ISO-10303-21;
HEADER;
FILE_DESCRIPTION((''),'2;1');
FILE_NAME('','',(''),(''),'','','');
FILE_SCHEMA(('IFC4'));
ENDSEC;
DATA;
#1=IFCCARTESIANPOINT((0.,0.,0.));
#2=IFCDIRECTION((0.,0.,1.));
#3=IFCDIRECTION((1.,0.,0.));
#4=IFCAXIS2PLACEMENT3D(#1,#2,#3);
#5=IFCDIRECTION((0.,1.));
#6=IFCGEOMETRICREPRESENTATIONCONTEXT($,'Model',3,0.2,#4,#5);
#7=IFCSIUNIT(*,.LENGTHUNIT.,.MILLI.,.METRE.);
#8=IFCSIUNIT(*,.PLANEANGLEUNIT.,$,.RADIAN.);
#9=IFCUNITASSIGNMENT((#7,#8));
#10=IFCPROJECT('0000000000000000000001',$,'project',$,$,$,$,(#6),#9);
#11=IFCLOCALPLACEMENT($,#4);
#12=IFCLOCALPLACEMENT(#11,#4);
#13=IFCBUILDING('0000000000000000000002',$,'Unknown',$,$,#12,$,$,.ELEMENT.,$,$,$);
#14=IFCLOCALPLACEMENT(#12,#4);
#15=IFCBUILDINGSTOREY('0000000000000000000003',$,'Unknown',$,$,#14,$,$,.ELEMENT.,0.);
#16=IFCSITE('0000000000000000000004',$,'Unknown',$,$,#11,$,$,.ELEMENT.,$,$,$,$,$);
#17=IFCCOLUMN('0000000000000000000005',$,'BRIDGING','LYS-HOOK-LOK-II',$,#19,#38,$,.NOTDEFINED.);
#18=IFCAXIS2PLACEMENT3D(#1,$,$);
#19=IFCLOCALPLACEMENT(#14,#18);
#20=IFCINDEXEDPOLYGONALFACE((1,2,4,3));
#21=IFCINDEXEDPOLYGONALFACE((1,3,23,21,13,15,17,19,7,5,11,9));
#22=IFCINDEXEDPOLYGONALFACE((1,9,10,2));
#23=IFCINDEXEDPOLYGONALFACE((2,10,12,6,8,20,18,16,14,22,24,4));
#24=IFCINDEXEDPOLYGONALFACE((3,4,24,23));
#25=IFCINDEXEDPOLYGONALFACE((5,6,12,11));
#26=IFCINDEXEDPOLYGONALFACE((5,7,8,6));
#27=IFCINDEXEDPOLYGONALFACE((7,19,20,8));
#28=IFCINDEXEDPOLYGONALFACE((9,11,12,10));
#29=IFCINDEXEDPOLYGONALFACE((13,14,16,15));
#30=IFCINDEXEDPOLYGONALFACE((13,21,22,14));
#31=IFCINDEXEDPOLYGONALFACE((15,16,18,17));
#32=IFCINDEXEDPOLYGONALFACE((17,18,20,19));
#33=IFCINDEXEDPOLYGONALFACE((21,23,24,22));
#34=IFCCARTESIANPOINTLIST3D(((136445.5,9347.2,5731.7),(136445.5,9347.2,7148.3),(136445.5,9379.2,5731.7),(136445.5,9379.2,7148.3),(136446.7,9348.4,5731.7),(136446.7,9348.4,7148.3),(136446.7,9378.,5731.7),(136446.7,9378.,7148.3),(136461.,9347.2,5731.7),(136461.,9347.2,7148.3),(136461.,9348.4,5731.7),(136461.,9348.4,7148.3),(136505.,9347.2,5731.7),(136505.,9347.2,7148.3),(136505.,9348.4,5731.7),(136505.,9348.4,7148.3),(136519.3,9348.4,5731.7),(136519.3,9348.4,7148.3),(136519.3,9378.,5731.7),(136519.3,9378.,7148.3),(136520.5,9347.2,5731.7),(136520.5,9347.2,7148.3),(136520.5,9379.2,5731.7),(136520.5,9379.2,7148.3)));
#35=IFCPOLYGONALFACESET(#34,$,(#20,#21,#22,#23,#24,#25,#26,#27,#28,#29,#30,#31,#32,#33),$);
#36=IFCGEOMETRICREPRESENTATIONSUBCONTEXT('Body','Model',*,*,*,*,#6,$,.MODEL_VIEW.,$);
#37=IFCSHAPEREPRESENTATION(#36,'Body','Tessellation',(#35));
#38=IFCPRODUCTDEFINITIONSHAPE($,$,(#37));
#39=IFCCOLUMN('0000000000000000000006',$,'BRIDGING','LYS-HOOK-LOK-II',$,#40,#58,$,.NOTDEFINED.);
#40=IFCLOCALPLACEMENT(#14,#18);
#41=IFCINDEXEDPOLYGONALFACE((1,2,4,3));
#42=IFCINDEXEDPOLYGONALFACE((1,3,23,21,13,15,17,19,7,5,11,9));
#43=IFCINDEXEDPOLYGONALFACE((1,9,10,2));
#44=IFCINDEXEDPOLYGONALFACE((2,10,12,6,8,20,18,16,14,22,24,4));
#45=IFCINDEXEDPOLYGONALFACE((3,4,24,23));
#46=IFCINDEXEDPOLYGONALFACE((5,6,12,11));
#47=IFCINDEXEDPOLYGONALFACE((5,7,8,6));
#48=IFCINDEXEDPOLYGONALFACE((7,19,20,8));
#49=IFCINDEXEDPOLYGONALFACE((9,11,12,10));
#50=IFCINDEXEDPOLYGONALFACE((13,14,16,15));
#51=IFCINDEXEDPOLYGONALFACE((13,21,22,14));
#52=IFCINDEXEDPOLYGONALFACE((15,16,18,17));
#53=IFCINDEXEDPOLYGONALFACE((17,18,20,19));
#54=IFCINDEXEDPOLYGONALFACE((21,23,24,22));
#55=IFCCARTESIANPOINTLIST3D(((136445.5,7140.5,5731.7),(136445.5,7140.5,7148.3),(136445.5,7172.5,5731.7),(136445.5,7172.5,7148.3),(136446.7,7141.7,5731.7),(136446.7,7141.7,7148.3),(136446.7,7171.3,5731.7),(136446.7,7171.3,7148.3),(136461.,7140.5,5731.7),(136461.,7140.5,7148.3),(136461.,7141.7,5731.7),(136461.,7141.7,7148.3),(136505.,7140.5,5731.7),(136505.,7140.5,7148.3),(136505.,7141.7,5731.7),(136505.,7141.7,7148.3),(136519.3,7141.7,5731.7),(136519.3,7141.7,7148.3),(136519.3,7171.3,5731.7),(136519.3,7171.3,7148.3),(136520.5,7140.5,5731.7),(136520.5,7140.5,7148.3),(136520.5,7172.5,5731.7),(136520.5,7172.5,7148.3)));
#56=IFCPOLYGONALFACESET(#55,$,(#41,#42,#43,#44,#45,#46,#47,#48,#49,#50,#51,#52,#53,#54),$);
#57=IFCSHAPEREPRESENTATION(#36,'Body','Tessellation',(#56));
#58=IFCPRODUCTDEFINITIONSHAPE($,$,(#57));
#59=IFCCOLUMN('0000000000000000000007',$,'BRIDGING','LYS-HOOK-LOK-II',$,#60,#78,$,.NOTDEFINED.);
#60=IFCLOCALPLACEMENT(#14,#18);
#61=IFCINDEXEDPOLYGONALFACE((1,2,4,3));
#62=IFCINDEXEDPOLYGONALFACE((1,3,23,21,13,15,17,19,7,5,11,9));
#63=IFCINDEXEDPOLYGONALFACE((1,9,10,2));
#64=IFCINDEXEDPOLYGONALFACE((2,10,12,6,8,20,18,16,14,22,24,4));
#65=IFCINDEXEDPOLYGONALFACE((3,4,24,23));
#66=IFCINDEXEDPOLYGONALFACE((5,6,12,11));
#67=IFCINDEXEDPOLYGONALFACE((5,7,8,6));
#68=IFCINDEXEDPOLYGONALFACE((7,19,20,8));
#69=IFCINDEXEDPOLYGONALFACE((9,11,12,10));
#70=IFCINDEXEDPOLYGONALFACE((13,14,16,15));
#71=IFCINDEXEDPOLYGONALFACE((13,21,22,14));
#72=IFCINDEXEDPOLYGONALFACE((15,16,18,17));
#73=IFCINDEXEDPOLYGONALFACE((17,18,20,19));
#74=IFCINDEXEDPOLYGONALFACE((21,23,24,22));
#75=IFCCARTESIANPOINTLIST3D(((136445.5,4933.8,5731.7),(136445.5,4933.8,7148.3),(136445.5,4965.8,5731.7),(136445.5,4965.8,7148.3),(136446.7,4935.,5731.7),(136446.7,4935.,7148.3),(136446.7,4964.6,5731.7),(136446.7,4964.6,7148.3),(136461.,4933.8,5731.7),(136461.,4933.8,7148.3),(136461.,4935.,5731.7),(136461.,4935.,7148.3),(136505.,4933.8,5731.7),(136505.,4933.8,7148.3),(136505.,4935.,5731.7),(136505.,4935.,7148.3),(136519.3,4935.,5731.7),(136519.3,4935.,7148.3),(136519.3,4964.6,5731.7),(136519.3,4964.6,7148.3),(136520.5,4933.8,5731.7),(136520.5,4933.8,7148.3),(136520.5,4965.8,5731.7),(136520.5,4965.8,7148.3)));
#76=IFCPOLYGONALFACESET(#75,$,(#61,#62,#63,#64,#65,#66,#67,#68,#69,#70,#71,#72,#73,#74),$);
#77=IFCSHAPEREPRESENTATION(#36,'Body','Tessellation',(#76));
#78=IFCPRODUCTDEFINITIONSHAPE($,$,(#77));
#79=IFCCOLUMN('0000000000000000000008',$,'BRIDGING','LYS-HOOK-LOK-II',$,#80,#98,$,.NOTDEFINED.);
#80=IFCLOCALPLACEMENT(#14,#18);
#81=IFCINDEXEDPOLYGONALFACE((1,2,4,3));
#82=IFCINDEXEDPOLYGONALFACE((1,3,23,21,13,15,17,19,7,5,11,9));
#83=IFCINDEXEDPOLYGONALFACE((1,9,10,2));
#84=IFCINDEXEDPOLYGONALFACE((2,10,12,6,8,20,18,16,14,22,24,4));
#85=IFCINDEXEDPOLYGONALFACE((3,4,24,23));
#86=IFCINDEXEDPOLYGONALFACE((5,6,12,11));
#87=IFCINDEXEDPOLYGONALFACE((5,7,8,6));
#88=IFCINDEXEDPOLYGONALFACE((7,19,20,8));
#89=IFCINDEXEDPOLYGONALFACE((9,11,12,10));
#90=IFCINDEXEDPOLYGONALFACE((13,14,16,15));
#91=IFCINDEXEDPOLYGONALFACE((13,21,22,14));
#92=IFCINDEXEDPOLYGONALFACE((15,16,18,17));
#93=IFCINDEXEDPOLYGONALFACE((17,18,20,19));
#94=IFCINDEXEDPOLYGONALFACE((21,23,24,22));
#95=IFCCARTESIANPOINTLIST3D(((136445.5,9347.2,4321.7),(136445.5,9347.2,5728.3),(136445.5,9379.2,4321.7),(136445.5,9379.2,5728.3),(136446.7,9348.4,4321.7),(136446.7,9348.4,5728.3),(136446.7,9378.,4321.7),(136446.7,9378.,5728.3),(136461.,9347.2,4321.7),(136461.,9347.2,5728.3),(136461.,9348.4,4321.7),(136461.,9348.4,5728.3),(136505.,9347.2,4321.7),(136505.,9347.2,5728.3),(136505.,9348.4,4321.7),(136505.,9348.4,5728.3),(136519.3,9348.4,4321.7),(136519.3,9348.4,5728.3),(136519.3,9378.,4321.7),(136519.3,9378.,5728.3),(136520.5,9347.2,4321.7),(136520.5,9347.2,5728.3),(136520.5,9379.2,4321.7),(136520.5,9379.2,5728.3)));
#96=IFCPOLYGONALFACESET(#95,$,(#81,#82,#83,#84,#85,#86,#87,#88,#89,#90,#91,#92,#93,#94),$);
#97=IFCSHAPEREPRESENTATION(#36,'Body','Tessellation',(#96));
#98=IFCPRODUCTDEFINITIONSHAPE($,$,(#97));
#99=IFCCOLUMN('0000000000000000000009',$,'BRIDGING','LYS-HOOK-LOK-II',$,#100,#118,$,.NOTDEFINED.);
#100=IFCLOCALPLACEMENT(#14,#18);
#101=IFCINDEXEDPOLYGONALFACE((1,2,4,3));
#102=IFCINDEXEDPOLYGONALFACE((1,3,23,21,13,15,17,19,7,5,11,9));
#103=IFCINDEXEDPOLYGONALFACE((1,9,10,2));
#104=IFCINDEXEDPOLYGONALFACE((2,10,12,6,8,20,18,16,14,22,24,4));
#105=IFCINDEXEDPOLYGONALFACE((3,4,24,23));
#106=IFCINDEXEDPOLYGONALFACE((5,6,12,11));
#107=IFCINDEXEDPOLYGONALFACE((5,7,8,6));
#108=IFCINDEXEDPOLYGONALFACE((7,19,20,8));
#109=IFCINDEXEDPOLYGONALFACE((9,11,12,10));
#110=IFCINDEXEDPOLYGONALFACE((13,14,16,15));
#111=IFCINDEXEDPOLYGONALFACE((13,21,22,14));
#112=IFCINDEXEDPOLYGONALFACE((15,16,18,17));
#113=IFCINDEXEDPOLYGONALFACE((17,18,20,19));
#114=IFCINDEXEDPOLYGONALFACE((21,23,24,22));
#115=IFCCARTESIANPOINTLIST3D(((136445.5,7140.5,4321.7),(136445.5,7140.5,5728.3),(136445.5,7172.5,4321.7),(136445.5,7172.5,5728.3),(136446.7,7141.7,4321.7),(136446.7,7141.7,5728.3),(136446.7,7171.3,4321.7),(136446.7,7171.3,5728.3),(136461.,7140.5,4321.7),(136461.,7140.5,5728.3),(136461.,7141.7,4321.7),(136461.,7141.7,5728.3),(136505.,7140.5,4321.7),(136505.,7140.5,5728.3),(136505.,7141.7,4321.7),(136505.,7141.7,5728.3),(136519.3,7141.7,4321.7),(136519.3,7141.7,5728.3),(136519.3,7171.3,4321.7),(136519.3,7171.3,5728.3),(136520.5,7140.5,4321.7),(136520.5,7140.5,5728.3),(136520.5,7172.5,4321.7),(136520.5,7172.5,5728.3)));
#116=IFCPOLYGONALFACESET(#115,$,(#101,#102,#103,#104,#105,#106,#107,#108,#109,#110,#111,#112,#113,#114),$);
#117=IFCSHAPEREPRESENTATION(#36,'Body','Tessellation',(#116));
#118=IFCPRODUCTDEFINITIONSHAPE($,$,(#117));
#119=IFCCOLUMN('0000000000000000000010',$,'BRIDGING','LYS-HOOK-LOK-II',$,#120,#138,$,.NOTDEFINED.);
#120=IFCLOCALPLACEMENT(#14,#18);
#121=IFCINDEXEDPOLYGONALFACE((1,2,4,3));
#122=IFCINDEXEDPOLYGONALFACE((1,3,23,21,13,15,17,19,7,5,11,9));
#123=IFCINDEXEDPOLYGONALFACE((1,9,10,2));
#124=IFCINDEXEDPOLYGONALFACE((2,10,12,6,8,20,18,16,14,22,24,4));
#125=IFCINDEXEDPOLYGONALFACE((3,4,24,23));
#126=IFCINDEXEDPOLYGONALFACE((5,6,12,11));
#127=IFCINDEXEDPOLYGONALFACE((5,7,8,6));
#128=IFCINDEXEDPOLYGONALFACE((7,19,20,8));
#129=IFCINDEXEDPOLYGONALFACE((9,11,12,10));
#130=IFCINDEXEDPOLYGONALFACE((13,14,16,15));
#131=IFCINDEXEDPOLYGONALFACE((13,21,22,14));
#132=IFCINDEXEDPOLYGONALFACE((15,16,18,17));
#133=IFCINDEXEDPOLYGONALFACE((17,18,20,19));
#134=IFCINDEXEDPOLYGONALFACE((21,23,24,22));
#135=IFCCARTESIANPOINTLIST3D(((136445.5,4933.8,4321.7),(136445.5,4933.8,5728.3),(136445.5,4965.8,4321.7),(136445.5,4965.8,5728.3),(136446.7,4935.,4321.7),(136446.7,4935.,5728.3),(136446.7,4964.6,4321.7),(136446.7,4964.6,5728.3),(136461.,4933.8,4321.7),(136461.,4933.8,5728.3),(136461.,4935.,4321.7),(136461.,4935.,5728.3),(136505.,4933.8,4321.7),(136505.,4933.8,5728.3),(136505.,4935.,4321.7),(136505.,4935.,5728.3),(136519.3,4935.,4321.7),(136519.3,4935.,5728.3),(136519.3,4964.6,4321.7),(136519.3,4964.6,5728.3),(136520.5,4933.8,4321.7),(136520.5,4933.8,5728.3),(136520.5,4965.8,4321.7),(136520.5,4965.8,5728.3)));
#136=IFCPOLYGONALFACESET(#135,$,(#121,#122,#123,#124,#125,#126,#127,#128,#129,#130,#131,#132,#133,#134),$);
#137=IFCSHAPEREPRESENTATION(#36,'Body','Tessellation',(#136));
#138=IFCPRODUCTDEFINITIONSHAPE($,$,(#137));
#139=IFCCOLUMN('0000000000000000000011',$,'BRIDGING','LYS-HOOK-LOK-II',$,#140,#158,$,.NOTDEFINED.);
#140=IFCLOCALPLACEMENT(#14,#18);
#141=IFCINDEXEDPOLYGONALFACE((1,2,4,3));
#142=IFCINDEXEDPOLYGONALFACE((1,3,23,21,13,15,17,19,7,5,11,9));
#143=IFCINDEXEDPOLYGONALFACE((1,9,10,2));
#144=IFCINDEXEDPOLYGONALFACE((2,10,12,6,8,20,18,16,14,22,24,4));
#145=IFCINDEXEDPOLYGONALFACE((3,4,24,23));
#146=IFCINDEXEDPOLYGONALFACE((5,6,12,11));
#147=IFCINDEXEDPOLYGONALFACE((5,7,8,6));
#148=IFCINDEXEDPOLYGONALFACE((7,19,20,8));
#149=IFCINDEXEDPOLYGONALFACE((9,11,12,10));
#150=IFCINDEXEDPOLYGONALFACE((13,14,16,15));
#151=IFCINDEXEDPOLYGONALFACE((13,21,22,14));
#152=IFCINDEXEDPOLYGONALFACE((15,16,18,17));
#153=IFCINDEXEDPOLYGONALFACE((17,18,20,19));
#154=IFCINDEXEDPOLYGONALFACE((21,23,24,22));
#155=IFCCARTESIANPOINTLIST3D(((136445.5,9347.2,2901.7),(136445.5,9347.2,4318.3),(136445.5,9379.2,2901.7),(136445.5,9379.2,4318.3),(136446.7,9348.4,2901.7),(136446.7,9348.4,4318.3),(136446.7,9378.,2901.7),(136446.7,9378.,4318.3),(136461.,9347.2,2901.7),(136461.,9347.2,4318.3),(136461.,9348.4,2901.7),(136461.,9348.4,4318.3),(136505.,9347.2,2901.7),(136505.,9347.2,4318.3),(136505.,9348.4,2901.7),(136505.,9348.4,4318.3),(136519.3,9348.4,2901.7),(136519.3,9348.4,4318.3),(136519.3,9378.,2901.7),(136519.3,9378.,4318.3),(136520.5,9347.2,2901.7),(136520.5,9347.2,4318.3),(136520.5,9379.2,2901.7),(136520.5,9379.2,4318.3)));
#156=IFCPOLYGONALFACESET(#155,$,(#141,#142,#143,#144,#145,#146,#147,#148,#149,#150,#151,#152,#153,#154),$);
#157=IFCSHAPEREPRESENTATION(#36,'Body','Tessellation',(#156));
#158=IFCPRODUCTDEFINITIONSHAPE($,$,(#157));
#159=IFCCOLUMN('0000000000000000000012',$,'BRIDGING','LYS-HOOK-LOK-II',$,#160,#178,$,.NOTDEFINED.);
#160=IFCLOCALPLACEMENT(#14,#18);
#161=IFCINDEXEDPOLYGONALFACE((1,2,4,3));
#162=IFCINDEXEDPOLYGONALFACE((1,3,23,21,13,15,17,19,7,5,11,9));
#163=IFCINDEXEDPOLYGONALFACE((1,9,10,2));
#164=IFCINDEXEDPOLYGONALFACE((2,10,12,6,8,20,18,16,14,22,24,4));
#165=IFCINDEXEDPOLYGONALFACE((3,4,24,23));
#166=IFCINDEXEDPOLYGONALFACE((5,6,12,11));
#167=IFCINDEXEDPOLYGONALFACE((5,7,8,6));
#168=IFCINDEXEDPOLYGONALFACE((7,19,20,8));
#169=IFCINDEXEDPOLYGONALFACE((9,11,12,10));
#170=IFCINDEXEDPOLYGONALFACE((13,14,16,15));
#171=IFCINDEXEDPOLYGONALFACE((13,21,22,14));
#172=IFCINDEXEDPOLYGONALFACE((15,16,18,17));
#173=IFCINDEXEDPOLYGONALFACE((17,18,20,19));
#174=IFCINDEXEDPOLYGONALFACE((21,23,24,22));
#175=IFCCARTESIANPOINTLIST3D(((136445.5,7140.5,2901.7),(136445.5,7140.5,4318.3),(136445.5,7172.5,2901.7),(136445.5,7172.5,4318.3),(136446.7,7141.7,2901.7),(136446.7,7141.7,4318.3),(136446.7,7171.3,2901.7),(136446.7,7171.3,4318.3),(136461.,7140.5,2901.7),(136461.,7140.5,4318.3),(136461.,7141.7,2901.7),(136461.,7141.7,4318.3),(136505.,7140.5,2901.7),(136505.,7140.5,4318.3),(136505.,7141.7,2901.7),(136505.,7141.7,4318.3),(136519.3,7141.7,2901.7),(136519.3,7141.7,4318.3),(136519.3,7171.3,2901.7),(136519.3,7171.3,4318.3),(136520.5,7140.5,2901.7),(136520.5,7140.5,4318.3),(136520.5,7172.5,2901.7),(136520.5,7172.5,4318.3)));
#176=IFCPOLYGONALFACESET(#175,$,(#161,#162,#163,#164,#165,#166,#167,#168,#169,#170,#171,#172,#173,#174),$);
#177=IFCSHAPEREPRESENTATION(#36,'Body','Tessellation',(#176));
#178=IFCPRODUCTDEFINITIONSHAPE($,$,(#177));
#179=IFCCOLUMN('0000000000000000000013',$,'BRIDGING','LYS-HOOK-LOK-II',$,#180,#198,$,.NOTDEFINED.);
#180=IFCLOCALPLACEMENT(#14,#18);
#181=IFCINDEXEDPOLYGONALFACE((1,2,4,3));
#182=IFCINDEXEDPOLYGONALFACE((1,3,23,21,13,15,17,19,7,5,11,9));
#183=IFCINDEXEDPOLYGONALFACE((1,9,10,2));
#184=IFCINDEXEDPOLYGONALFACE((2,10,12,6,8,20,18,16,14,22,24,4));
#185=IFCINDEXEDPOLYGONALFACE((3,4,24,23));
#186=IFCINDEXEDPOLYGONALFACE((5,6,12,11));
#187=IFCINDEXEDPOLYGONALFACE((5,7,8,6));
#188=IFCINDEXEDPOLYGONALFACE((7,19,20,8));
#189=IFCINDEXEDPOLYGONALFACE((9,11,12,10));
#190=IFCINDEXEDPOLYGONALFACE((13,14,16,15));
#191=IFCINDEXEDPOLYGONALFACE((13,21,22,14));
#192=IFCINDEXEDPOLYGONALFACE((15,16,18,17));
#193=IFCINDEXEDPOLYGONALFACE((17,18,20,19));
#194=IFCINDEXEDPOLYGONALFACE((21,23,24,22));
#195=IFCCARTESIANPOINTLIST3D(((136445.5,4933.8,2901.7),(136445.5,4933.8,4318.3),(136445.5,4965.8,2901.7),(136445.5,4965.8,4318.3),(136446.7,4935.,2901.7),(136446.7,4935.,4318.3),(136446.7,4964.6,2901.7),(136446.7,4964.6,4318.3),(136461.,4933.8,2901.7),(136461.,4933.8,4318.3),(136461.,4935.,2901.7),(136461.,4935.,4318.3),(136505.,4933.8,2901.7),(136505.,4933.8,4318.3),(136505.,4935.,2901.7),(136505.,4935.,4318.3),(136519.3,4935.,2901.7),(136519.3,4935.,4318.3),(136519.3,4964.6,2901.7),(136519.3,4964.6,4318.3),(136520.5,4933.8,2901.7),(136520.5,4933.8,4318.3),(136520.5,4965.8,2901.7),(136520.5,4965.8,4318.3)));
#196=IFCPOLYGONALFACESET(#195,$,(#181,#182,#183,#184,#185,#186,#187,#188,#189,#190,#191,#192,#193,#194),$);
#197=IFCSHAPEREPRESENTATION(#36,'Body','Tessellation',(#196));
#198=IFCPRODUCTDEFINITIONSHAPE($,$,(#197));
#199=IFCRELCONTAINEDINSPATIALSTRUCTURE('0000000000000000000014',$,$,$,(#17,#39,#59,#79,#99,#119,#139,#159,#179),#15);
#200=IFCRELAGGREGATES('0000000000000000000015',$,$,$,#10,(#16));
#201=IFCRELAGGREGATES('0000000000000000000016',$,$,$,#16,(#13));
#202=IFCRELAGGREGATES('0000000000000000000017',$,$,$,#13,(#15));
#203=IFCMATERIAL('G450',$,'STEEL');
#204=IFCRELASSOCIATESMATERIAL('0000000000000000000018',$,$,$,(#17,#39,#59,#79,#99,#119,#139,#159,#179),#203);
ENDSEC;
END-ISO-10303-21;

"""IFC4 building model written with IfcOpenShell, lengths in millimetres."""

from ifc_helpers import new_model, si_unit, direction, frame, origin_with_axes, place, context, subcontext, project, spatial, line, indexed_curve, outline, extrude, material, element, save


model = new_model("IFC4")

# Units and contexts
model_context = context("Model", 3, precision=0.2, world=origin_with_axes(), true_north=direction((0.0, 1.0)))
body_context = subcontext(model_context, "Body", "Model", "MODEL_VIEW")
ifc_project = project(units=[si_unit("LENGTHUNIT", "METRE", prefix="MILLI"), si_unit("PLANEANGLEUNIT", "RADIAN")], contexts=[model_context])

# Site, building, storey
site_placement = place(None, origin_with_axes())
site = spatial("IfcSite", under=ifc_project, at=site_placement, Name="Unknown", CompositionType="ELEMENT")
building_placement = place(site_placement, origin_with_axes())
building = spatial("IfcBuilding", under=site, at=building_placement, Name="Unknown", CompositionType="ELEMENT")
storey_placement = place(building_placement, origin_with_axes())
storey = spatial("IfcBuildingStorey", under=building, at=storey_placement, Name="Unknown", CompositionType="ELEMENT", Elevation=0.0)

# Columns
ifc_material_1 = material(Name="G450", Category="STEEL")
for number, where, z_axis, x_axis, name in (
    (1, (136483.0, 9363.2, 5731.7), (0.0, -1.0, 0.0), (0.0, 0.0, 1.0), "BRIDGING"),
    (2, (136483.0, 7156.5, 5731.7), (0.0, -1.0, 0.0), (0.0, 0.0, 1.0), "BRIDGING"),
    (3, (136483.0, 4949.8, 5731.7), (0.0, -1.0, 0.0), (0.0, 0.0, 1.0), "BRIDGING"),
):
    element("IfcColumn", number, at=place(storey_placement, frame(where, z_axis=z_axis, x_axis=x_axis)), inside=storey, material=ifc_material_1, Name=name, Description="LYS-HOOK-LOK-II", PredefinedType="NOTDEFINED", context=body_context, shape_type="SolidModel", body=[
        extrude(outline(indexed_curve([(16.0, -37.5), (16.0, -22.0), (14.8, -22.0), (14.8, -36.3), (-14.8, -36.3), (-14.8, 36.3), (14.8, 36.3), (14.8, 22.0), (16.0, 22.0), (16.0, 37.5), (-16.0, 37.5), (-16.0, -37.5)], segments=[line(1, 2, 3, 4, 5, 6, 7, 8, 9, 10, 11, 12, 1)])), frame((0.0, 0.0, 0.0), z_axis=(-1.0, 0.0, 0.0), x_axis=(0.0, 0.0, 1.0)), (0.0, 0.0, -1.0), 1416.6),
    ])
for number, where, z_axis, x_axis, name in (
    (4, (136483.0, 9363.2, 4321.7), (0.0, -1.0, 0.0), (0.0, 0.0, 1.0), "BRIDGING"),
    (5, (136483.0, 7156.5, 4321.7), (0.0, -1.0, 0.0), (0.0, 0.0, 1.0), "BRIDGING"),
    (6, (136483.0, 4949.8, 4321.7), (0.0, -1.0, 0.0), (0.0, 0.0, 1.0), "BRIDGING"),
):
    element("IfcColumn", number, at=place(storey_placement, frame(where, z_axis=z_axis, x_axis=x_axis)), inside=storey, material=ifc_material_1, Name=name, Description="LYS-HOOK-LOK-II", PredefinedType="NOTDEFINED", context=body_context, shape_type="SolidModel", body=[
        extrude(outline(indexed_curve([(16.0, -37.5), (16.0, -22.0), (14.8, -22.0), (14.8, -36.3), (-14.8, -36.3), (-14.8, 36.3), (14.8, 36.3), (14.8, 22.0), (16.0, 22.0), (16.0, 37.5), (-16.0, 37.5), (-16.0, -37.5)], segments=[line(1, 2, 3, 4, 5, 6, 7, 8, 9, 10, 11, 12, 1)])), frame((0.0, 0.0, 0.0), z_axis=(-1.0, 0.0, 0.0), x_axis=(0.0, 0.0, 1.0)), (0.0, 0.0, -1.0), 1406.6),
    ])
for number, where, z_axis, x_axis, name in (
    (7, (136483.0, 9363.2, 2901.7), (0.0, -1.0, 0.0), (0.0, 0.0, 1.0), "BRIDGING"),
    (8, (136483.0, 7156.5, 2901.7), (0.0, -1.0, 0.0), (0.0, 0.0, 1.0), "BRIDGING"),
    (9, (136483.0, 4949.8, 2901.7), (0.0, -1.0, 0.0), (0.0, 0.0, 1.0), "BRIDGING"),
):
    element("IfcColumn", number, at=place(storey_placement, frame(where, z_axis=z_axis, x_axis=x_axis)), inside=storey, material=ifc_material_1, Name=name, Description="LYS-HOOK-LOK-II", PredefinedType="NOTDEFINED", context=body_context, shape_type="SolidModel", body=[
        extrude(outline(indexed_curve([(16.0, -37.5), (16.0, -22.0), (14.8, -22.0), (14.8, -36.3), (-14.8, -36.3), (-14.8, 36.3), (14.8, 36.3), (14.8, 22.0), (16.0, 22.0), (16.0, 37.5), (-16.0, 37.5), (-16.0, -37.5)], segments=[line(1, 2, 3, 4, 5, 6, 7, 8, 9, 10, 11, 12, 1)])), frame((0.0, 0.0, 0.0), z_axis=(-1.0, 0.0, 0.0), x_axis=(0.0, 0.0, 1.0)), (0.0, 0.0, -1.0), 1416.6),
    ])

save(model, "model.ifc")
